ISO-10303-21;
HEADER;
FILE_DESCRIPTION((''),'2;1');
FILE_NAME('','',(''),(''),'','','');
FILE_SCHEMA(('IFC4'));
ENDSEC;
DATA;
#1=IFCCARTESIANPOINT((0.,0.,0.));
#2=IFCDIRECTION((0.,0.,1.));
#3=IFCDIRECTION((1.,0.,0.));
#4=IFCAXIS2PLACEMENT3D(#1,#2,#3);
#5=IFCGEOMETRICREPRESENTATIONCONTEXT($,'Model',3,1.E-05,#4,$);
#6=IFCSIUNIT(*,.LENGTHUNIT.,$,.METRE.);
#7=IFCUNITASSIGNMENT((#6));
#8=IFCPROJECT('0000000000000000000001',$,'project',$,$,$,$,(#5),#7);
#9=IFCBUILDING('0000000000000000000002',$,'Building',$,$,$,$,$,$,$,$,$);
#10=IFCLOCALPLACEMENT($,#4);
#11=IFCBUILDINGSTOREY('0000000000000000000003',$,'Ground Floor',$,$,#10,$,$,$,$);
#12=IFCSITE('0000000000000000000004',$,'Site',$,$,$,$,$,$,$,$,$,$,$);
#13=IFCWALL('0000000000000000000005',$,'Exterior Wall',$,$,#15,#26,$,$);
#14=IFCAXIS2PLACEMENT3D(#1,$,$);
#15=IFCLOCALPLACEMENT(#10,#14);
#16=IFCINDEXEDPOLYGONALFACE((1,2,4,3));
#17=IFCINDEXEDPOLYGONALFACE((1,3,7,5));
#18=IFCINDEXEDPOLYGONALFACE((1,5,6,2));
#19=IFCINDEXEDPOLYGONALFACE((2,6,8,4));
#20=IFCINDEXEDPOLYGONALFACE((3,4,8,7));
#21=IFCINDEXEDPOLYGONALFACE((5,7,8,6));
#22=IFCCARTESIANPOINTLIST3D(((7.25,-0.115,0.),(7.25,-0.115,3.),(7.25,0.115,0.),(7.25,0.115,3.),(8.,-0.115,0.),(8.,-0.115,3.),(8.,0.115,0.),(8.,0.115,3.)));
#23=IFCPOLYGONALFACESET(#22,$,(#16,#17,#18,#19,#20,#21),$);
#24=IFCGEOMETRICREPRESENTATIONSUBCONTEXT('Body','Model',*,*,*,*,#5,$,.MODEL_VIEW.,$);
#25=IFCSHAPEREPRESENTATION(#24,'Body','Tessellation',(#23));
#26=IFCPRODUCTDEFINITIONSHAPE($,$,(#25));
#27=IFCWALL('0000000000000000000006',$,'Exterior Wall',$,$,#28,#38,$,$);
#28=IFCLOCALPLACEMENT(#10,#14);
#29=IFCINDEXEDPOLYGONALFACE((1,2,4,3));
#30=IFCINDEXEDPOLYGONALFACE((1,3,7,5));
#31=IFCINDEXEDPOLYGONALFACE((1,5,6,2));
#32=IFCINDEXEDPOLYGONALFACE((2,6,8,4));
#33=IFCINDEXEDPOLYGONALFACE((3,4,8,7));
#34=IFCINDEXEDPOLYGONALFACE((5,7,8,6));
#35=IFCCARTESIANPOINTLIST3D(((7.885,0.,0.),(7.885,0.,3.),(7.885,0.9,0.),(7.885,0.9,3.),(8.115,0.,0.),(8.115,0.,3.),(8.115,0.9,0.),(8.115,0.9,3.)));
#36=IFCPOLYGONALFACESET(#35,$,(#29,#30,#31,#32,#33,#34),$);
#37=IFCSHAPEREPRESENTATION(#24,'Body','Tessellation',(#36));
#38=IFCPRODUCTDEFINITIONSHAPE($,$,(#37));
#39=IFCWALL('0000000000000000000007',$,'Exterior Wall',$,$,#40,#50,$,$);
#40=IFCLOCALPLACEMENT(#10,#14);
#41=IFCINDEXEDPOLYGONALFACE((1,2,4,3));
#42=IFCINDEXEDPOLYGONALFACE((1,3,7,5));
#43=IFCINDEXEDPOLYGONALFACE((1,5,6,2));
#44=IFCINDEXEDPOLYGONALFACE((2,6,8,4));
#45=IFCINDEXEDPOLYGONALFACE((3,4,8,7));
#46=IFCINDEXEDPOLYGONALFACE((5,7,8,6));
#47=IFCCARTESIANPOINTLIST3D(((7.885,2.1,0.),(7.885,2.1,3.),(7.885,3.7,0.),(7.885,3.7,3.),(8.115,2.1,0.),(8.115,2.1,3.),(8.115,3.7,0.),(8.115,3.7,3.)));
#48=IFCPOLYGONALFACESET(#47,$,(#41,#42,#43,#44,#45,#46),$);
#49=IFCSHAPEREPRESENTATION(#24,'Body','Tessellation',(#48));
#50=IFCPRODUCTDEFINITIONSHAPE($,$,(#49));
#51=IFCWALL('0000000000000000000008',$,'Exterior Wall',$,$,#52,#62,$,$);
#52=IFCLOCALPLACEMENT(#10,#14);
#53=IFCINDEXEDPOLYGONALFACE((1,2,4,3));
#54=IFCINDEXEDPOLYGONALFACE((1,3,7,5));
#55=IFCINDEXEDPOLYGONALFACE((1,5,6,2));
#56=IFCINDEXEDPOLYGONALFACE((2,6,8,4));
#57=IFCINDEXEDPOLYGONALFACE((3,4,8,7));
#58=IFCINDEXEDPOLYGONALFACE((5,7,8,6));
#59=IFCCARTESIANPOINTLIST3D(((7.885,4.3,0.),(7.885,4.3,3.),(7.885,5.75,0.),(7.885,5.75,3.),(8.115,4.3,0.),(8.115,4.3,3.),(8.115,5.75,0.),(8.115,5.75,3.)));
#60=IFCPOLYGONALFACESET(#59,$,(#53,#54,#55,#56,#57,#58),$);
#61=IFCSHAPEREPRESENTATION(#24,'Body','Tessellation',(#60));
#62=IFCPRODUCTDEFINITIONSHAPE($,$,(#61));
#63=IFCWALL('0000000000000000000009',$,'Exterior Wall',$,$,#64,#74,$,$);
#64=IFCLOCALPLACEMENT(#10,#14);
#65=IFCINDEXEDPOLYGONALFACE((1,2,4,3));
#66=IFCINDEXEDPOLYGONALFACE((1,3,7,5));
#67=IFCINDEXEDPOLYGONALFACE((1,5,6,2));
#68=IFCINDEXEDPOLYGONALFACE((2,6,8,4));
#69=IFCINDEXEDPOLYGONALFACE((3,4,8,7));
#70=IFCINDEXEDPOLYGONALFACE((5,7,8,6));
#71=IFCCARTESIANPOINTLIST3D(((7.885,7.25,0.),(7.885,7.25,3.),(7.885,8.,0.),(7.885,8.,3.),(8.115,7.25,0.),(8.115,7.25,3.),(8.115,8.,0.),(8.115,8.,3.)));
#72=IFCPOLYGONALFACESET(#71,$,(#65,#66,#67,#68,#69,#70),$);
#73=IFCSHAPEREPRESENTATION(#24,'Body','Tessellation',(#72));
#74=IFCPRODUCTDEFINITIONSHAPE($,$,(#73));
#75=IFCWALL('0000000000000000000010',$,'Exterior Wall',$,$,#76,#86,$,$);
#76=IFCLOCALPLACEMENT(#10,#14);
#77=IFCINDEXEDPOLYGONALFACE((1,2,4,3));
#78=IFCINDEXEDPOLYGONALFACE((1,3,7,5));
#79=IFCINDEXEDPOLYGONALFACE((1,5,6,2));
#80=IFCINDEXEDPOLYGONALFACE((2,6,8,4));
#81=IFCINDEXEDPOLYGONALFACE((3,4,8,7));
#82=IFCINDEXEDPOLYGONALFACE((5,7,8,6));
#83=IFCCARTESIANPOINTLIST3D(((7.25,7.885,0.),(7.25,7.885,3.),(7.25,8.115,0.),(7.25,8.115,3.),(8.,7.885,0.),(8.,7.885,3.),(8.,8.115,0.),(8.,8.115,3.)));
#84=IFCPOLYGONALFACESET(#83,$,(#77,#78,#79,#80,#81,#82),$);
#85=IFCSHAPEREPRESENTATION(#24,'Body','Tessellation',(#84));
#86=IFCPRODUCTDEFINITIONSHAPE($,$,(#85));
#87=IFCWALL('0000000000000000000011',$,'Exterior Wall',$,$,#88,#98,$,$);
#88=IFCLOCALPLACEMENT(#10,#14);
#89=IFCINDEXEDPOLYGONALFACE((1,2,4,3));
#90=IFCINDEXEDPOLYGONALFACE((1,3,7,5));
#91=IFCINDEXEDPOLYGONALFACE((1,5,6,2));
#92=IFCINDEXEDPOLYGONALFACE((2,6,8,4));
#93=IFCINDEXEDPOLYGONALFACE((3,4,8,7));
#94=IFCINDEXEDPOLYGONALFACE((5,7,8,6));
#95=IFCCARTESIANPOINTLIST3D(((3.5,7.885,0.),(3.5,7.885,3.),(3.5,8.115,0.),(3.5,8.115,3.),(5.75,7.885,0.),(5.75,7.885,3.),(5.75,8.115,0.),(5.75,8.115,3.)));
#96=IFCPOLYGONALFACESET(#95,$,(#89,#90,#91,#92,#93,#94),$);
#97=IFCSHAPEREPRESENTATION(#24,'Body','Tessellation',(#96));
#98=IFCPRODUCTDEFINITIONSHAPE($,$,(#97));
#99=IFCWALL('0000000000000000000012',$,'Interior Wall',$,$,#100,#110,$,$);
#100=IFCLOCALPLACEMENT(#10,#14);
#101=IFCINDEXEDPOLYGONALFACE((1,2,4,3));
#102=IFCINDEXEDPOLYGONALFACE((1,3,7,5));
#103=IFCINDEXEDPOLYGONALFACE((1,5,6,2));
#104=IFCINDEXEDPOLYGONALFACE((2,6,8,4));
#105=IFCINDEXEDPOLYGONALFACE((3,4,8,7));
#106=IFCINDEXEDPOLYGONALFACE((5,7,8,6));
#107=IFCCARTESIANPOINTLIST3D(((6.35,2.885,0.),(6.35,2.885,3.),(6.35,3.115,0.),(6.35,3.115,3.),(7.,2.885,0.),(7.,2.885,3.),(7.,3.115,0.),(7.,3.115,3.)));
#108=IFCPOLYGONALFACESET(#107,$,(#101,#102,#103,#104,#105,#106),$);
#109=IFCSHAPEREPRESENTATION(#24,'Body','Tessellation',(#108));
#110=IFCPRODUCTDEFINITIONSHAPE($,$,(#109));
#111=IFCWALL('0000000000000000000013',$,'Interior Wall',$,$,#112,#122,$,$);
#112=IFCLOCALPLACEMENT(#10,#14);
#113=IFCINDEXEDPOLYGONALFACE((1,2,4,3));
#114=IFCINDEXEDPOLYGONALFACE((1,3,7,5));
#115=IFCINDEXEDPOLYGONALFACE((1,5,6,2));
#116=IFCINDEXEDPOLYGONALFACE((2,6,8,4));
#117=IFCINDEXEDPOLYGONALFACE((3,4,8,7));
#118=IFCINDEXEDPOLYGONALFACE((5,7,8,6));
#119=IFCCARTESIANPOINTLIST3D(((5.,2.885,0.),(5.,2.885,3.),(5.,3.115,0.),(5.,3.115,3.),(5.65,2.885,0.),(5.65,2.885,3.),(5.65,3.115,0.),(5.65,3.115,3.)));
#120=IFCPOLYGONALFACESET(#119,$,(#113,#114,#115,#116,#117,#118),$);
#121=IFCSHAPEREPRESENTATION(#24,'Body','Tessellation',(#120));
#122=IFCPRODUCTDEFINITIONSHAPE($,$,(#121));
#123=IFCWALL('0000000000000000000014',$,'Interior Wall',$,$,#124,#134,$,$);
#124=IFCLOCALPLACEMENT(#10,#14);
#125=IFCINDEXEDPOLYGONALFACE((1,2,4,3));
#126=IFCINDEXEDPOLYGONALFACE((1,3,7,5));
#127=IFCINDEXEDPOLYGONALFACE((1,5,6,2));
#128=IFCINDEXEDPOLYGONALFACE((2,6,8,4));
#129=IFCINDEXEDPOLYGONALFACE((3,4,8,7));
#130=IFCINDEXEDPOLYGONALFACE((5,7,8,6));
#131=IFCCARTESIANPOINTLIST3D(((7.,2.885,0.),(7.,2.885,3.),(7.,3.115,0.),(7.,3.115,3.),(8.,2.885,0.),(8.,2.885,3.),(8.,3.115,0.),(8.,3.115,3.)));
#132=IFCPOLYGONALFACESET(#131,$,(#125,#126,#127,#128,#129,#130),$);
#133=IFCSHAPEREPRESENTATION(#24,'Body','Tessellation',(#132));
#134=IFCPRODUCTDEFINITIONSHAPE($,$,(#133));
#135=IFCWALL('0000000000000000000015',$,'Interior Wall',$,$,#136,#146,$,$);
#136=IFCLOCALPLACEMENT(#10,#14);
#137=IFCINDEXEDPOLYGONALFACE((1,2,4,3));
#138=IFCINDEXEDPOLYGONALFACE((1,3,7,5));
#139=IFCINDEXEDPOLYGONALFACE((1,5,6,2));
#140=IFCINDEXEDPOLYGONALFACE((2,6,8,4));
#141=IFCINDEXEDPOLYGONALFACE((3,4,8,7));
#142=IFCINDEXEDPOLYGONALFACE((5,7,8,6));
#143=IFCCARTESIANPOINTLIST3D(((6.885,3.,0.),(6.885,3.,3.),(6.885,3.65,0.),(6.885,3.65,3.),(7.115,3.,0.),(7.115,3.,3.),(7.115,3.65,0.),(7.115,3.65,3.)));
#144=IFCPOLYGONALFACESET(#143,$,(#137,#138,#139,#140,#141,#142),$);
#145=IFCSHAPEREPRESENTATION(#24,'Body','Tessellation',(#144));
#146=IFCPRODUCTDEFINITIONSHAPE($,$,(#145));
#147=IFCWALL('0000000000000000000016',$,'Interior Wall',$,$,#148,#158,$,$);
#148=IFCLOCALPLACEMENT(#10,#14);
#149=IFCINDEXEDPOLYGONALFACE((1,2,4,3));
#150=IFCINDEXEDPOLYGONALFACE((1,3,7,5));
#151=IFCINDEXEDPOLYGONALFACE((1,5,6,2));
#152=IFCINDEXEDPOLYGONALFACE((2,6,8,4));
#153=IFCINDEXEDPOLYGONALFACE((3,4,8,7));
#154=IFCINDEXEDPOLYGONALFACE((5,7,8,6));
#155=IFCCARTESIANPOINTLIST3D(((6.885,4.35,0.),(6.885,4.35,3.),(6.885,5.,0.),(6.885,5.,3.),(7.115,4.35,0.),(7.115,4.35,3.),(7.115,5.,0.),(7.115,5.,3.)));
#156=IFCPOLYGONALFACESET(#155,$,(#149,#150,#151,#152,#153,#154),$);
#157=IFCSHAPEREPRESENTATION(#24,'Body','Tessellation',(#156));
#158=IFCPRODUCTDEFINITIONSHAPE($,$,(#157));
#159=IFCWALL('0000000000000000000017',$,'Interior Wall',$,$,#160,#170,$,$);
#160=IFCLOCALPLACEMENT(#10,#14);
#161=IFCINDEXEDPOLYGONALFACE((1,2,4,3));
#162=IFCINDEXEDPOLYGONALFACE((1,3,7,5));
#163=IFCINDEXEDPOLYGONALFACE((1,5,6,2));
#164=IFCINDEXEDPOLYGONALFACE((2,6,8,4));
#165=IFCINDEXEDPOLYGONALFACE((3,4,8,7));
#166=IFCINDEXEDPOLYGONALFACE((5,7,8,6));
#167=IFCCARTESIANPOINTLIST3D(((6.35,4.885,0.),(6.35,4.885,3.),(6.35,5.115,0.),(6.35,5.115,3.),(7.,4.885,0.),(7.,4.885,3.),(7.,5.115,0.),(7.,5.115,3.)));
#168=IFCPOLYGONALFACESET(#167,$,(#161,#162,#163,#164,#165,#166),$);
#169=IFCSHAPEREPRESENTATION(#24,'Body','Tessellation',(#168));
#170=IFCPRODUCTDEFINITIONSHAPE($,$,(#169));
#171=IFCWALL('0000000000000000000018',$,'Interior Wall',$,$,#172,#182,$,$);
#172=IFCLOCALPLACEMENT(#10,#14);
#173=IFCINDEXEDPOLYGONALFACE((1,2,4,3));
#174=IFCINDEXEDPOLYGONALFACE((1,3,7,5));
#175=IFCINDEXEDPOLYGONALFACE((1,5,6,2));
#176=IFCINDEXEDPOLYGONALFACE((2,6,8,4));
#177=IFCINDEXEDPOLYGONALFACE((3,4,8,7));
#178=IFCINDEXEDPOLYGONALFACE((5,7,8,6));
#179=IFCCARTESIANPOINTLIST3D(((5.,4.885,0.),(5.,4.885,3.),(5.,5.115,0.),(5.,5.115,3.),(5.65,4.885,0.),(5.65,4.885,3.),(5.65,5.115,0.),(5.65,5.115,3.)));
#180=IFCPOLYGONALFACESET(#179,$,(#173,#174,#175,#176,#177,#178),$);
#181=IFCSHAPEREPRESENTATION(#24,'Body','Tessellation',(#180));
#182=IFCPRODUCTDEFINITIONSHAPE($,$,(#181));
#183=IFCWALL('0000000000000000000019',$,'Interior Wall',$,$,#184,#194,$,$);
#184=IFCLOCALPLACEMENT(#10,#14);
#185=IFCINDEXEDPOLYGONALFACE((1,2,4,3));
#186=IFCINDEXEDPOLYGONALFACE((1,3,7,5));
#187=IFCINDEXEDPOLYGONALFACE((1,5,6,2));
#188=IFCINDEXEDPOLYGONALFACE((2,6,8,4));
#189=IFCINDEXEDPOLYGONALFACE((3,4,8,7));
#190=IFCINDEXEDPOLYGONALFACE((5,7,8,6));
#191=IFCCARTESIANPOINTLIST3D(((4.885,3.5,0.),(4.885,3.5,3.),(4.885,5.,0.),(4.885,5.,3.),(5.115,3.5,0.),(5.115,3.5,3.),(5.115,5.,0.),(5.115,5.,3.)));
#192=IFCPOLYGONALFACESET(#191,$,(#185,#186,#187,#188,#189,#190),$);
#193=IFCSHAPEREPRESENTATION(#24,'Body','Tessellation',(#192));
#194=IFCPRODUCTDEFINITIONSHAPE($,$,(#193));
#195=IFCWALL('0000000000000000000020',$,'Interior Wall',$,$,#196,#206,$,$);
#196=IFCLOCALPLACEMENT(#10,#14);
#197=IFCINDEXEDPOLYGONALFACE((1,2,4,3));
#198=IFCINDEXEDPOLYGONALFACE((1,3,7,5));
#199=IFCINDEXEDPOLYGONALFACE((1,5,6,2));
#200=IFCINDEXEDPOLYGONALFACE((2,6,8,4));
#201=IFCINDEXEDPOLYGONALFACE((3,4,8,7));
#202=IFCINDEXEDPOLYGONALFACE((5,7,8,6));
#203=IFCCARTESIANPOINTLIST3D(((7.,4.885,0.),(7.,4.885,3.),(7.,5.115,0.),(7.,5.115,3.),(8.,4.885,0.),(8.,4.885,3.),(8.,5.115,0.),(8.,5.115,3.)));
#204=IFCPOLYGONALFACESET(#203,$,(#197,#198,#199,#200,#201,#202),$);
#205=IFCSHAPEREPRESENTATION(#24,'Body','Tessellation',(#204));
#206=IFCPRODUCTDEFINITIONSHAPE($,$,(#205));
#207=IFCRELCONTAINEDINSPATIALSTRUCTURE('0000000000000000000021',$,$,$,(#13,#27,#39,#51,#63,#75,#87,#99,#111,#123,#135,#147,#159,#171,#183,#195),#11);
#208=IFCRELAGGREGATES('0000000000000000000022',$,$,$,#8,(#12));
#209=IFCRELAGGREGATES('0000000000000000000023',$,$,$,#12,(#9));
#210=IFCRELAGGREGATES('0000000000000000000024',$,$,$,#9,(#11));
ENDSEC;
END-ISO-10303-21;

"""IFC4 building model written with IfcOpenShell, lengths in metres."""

from ifc_helpers import new_model, si_unit, frame, origin_with_axes, place, context, subcontext, project, spatial, indexed_curve, outline, extrude, element, save


model = new_model("IFC4")

# Units and contexts
model_context = context("Model", 3, precision=1e-05, world=origin_with_axes())
body_context = subcontext(model_context, "Body", "Model", "MODEL_VIEW")
ifc_project = project(units=[si_unit("LENGTHUNIT", "METRE")], contexts=[model_context])

# Site, building, storey
site = spatial("IfcSite", under=ifc_project, Name="Site")
building = spatial("IfcBuilding", under=site, Name="Building")
storey_placement = place(None, origin_with_axes())
storey = spatial("IfcBuildingStorey", under=building, at=storey_placement, Name="Ground Floor")

# Walls
wall_1_placement = place(storey_placement, frame((7.25, 0.0, 0.0), z_axis=(0.0, 0.0, 1.0), x_axis=(1.0, 0.0, 0.0)))
element("IfcWall", 1, at=wall_1_placement, inside=storey, Name="Exterior Wall", context=body_context, shape_type="SweptSolid", body=[
    extrude(outline(indexed_curve([(0.0, 0.0), (0.0, 0.23), (0.75, 0.23), (0.75, 0.0), (0.0, 0.0)], self_intersect=False)), frame((0.0, -0.115, 0.0), z_axis=(0.0, 0.0, 1.0), x_axis=(1.0, 0.0, 0.0)), (0.0, 0.0, 1.0), 3.0),
])
wall_2_placement = place(storey_placement, frame((8.0, 0.0, 0.0), z_axis=(0.0, 0.0, 1.0), x_axis=(0.0, 1.0, 0.0)))
element("IfcWall", 2, at=wall_2_placement, inside=storey, Name="Exterior Wall", context=body_context, shape_type="SweptSolid", body=[
    extrude(outline(indexed_curve([(0.0, 0.0), (0.0, 0.23), (0.9, 0.23), (0.9, 0.0), (0.0, 0.0)], self_intersect=False)), frame((0.0, -0.115, 0.0), z_axis=(0.0, 0.0, 1.0), x_axis=(1.0, 0.0, 0.0)), (0.0, 0.0, 1.0), 3.0),
])
wall_3_placement = place(storey_placement, frame((8.0, 2.1, 0.0), z_axis=(0.0, 0.0, 1.0), x_axis=(0.0, 1.0, 0.0)))
element("IfcWall", 3, at=wall_3_placement, inside=storey, Name="Exterior Wall", context=body_context, shape_type="SweptSolid", body=[
    extrude(outline(indexed_curve([(0.0, 0.0), (0.0, 0.23), (1.6, 0.23), (1.6, 0.0), (0.0, 0.0)], self_intersect=False)), frame((0.0, -0.115, 0.0), z_axis=(0.0, 0.0, 1.0), x_axis=(1.0, 0.0, 0.0)), (0.0, 0.0, 1.0), 3.0),
])
wall_4_placement = place(storey_placement, frame((8.0, 4.3, 0.0), z_axis=(0.0, 0.0, 1.0), x_axis=(0.0, 1.0, 0.0)))
element("IfcWall", 4, at=wall_4_placement, inside=storey, Name="Exterior Wall", context=body_context, shape_type="SweptSolid", body=[
    extrude(outline(indexed_curve([(0.0, 0.0), (0.0, 0.23), (1.45, 0.23), (1.45, 0.0), (0.0, 0.0)], self_intersect=False)), frame((0.0, -0.115, 0.0), z_axis=(0.0, 0.0, 1.0), x_axis=(1.0, 0.0, 0.0)), (0.0, 0.0, 1.0), 3.0),
])
for number, where, z_axis, x_axis, name in (
    (5, (8.0, 7.25, 0.0), (0.0, 0.0, 1.0), (0.0, 1.0, 0.0), "Exterior Wall"),
    (6, (8.0, 8.0, 0.0), (0.0, 0.0, 1.0), (-1.0, 0.0, 0.0), "Exterior Wall"),
):
    element("IfcWall", number, at=place(storey_placement, frame(where, z_axis=z_axis, x_axis=x_axis)), inside=storey, Name=name, context=body_context, shape_type="SweptSolid", body=[
        extrude(outline(indexed_curve([(0.0, 0.0), (0.0, 0.23), (0.75, 0.23), (0.75, 0.0), (0.0, 0.0)], self_intersect=False)), frame((0.0, -0.115, 0.0), z_axis=(0.0, 0.0, 1.0), x_axis=(1.0, 0.0, 0.0)), (0.0, 0.0, 1.0), 3.0),
    ])
wall_5_placement = place(storey_placement, frame((5.75, 8.0, 0.0), z_axis=(0.0, 0.0, 1.0), x_axis=(-1.0, 0.0, 0.0)))
element("IfcWall", 7, at=wall_5_placement, inside=storey, Name="Exterior Wall", context=body_context, shape_type="SweptSolid", body=[
    extrude(outline(indexed_curve([(0.0, 0.0), (0.0, 0.23), (2.25, 0.23), (2.25, 0.0), (0.0, 0.0)], self_intersect=False)), frame((0.0, -0.115, 0.0), z_axis=(0.0, 0.0, 1.0), x_axis=(1.0, 0.0, 0.0)), (0.0, 0.0, 1.0), 3.0),
])
for number, where, z_axis, x_axis, name in (
    (8, (7.0, 3.0, 0.0), (0.0, 0.0, 1.0), (-1.0, 0.0, 0.0), "Interior Wall"),
    (9, (5.65, 3.0, 0.0), (0.0, 0.0, 1.0), (-1.0, 0.0, 0.0), "Interior Wall"),
):
    element("IfcWall", number, at=place(storey_placement, frame(where, z_axis=z_axis, x_axis=x_axis)), inside=storey, Name=name, context=body_context, shape_type="SweptSolid", body=[
        extrude(outline(indexed_curve([(0.0, 0.0), (0.0, 0.23), (0.65, 0.23), (0.65, 0.0), (0.0, 0.0)], self_intersect=False)), frame((0.0, -0.115, 0.0), z_axis=(0.0, 0.0, 1.0), x_axis=(1.0, 0.0, 0.0)), (0.0, 0.0, 1.0), 3.0),
    ])
wall_6_placement = place(storey_placement, frame((8.0, 3.0, 0.0), z_axis=(0.0, 0.0, 1.0), x_axis=(-1.0, 0.0, 0.0)))
element("IfcWall", 10, at=wall_6_placement, inside=storey, Name="Interior Wall", context=body_context, shape_type="SweptSolid", body=[
    extrude(outline(indexed_curve([(0.0, 0.0), (0.0, 0.23), (1.0, 0.23), (1.0, 0.0), (0.0, 0.0)], self_intersect=False)), frame((0.0, -0.115, 0.0), z_axis=(0.0, 0.0, 1.0), x_axis=(1.0, 0.0, 0.0)), (0.0, 0.0, 1.0), 3.0),
])
wall_7_placement = place(storey_placement, frame((7.0, 3.0, 0.0), z_axis=(0.0, 0.0, 1.0), x_axis=(0.0, 1.0, 0.0)))
element("IfcWall", 11, at=wall_7_placement, inside=storey, Name="Interior Wall", context=body_context, shape_type="SweptSolid", body=[
    extrude(outline(indexed_curve([(0.0, 0.0), (0.0, 0.23), (0.65, 0.23), (0.65, 0.0), (0.0, 0.0)], self_intersect=False)), frame((0.0, -0.115, 0.0), z_axis=(0.0, 0.0, 1.0), x_axis=(1.0, 0.0, 0.0)), (0.0, 0.0, 1.0), 3.0),
])
for number, where, z_axis, x_axis, name in (
    (12, (7.0, 4.35, 0.0), (0.0, 0.0, 1.0), (0.0, 1.0, 0.0), "Interior Wall"),
    (13, (7.0, 5.0, 0.0), (0.0, 0.0, 1.0), (-1.0, 0.0, 0.0), "Interior Wall"),
    (14, (5.65, 5.0, 0.0), (0.0, 0.0, 1.0), (-1.0, 0.0, 0.0), "Interior Wall"),
):
    element("IfcWall", number, at=place(storey_placement, frame(where, z_axis=z_axis, x_axis=x_axis)), inside=storey, Name=name, context=body_context, shape_type="SweptSolid", body=[
        extrude(outline(indexed_curve([(0.0, 0.0), (0.0, 0.23), (0.65, 0.23), (0.65, 0.0), (0.0, 0.0)], self_intersect=False)), frame((0.0, -0.115, 0.0), z_axis=(0.0, 0.0, 1.0), x_axis=(1.0, 0.0, 0.0)), (0.0, 0.0, 1.0), 3.0),
    ])
wall_8_placement = place(storey_placement, frame((5.0, 5.0, 0.0), z_axis=(0.0, 0.0, 1.0), x_axis=(0.0, -1.0, 0.0)))
element("IfcWall", 15, at=wall_8_placement, inside=storey, Name="Interior Wall", context=body_context, shape_type="SweptSolid", body=[
    extrude(outline(indexed_curve([(0.0, 0.0), (0.0, 0.23), (1.5, 0.23), (1.5, 0.0), (0.0, 0.0)], self_intersect=False)), frame((0.0, -0.115, 0.0), z_axis=(0.0, 0.0, 1.0), x_axis=(1.0, 0.0, 0.0)), (0.0, 0.0, 1.0), 3.0),
])
wall_9_placement = place(storey_placement, frame((8.0, 5.0, 0.0), z_axis=(0.0, 0.0, 1.0), x_axis=(-1.0, 0.0, 0.0)))
element("IfcWall", 16, at=wall_9_placement, inside=storey, Name="Interior Wall", context=body_context, shape_type="SweptSolid", body=[
    extrude(outline(indexed_curve([(0.0, 0.0), (0.0, 0.23), (1.0, 0.23), (1.0, 0.0), (0.0, 0.0)], self_intersect=False)), frame((0.0, -0.115, 0.0), z_axis=(0.0, 0.0, 1.0), x_axis=(1.0, 0.0, 0.0)), (0.0, 0.0, 1.0), 3.0),
])

save(model, "model.ifc")
